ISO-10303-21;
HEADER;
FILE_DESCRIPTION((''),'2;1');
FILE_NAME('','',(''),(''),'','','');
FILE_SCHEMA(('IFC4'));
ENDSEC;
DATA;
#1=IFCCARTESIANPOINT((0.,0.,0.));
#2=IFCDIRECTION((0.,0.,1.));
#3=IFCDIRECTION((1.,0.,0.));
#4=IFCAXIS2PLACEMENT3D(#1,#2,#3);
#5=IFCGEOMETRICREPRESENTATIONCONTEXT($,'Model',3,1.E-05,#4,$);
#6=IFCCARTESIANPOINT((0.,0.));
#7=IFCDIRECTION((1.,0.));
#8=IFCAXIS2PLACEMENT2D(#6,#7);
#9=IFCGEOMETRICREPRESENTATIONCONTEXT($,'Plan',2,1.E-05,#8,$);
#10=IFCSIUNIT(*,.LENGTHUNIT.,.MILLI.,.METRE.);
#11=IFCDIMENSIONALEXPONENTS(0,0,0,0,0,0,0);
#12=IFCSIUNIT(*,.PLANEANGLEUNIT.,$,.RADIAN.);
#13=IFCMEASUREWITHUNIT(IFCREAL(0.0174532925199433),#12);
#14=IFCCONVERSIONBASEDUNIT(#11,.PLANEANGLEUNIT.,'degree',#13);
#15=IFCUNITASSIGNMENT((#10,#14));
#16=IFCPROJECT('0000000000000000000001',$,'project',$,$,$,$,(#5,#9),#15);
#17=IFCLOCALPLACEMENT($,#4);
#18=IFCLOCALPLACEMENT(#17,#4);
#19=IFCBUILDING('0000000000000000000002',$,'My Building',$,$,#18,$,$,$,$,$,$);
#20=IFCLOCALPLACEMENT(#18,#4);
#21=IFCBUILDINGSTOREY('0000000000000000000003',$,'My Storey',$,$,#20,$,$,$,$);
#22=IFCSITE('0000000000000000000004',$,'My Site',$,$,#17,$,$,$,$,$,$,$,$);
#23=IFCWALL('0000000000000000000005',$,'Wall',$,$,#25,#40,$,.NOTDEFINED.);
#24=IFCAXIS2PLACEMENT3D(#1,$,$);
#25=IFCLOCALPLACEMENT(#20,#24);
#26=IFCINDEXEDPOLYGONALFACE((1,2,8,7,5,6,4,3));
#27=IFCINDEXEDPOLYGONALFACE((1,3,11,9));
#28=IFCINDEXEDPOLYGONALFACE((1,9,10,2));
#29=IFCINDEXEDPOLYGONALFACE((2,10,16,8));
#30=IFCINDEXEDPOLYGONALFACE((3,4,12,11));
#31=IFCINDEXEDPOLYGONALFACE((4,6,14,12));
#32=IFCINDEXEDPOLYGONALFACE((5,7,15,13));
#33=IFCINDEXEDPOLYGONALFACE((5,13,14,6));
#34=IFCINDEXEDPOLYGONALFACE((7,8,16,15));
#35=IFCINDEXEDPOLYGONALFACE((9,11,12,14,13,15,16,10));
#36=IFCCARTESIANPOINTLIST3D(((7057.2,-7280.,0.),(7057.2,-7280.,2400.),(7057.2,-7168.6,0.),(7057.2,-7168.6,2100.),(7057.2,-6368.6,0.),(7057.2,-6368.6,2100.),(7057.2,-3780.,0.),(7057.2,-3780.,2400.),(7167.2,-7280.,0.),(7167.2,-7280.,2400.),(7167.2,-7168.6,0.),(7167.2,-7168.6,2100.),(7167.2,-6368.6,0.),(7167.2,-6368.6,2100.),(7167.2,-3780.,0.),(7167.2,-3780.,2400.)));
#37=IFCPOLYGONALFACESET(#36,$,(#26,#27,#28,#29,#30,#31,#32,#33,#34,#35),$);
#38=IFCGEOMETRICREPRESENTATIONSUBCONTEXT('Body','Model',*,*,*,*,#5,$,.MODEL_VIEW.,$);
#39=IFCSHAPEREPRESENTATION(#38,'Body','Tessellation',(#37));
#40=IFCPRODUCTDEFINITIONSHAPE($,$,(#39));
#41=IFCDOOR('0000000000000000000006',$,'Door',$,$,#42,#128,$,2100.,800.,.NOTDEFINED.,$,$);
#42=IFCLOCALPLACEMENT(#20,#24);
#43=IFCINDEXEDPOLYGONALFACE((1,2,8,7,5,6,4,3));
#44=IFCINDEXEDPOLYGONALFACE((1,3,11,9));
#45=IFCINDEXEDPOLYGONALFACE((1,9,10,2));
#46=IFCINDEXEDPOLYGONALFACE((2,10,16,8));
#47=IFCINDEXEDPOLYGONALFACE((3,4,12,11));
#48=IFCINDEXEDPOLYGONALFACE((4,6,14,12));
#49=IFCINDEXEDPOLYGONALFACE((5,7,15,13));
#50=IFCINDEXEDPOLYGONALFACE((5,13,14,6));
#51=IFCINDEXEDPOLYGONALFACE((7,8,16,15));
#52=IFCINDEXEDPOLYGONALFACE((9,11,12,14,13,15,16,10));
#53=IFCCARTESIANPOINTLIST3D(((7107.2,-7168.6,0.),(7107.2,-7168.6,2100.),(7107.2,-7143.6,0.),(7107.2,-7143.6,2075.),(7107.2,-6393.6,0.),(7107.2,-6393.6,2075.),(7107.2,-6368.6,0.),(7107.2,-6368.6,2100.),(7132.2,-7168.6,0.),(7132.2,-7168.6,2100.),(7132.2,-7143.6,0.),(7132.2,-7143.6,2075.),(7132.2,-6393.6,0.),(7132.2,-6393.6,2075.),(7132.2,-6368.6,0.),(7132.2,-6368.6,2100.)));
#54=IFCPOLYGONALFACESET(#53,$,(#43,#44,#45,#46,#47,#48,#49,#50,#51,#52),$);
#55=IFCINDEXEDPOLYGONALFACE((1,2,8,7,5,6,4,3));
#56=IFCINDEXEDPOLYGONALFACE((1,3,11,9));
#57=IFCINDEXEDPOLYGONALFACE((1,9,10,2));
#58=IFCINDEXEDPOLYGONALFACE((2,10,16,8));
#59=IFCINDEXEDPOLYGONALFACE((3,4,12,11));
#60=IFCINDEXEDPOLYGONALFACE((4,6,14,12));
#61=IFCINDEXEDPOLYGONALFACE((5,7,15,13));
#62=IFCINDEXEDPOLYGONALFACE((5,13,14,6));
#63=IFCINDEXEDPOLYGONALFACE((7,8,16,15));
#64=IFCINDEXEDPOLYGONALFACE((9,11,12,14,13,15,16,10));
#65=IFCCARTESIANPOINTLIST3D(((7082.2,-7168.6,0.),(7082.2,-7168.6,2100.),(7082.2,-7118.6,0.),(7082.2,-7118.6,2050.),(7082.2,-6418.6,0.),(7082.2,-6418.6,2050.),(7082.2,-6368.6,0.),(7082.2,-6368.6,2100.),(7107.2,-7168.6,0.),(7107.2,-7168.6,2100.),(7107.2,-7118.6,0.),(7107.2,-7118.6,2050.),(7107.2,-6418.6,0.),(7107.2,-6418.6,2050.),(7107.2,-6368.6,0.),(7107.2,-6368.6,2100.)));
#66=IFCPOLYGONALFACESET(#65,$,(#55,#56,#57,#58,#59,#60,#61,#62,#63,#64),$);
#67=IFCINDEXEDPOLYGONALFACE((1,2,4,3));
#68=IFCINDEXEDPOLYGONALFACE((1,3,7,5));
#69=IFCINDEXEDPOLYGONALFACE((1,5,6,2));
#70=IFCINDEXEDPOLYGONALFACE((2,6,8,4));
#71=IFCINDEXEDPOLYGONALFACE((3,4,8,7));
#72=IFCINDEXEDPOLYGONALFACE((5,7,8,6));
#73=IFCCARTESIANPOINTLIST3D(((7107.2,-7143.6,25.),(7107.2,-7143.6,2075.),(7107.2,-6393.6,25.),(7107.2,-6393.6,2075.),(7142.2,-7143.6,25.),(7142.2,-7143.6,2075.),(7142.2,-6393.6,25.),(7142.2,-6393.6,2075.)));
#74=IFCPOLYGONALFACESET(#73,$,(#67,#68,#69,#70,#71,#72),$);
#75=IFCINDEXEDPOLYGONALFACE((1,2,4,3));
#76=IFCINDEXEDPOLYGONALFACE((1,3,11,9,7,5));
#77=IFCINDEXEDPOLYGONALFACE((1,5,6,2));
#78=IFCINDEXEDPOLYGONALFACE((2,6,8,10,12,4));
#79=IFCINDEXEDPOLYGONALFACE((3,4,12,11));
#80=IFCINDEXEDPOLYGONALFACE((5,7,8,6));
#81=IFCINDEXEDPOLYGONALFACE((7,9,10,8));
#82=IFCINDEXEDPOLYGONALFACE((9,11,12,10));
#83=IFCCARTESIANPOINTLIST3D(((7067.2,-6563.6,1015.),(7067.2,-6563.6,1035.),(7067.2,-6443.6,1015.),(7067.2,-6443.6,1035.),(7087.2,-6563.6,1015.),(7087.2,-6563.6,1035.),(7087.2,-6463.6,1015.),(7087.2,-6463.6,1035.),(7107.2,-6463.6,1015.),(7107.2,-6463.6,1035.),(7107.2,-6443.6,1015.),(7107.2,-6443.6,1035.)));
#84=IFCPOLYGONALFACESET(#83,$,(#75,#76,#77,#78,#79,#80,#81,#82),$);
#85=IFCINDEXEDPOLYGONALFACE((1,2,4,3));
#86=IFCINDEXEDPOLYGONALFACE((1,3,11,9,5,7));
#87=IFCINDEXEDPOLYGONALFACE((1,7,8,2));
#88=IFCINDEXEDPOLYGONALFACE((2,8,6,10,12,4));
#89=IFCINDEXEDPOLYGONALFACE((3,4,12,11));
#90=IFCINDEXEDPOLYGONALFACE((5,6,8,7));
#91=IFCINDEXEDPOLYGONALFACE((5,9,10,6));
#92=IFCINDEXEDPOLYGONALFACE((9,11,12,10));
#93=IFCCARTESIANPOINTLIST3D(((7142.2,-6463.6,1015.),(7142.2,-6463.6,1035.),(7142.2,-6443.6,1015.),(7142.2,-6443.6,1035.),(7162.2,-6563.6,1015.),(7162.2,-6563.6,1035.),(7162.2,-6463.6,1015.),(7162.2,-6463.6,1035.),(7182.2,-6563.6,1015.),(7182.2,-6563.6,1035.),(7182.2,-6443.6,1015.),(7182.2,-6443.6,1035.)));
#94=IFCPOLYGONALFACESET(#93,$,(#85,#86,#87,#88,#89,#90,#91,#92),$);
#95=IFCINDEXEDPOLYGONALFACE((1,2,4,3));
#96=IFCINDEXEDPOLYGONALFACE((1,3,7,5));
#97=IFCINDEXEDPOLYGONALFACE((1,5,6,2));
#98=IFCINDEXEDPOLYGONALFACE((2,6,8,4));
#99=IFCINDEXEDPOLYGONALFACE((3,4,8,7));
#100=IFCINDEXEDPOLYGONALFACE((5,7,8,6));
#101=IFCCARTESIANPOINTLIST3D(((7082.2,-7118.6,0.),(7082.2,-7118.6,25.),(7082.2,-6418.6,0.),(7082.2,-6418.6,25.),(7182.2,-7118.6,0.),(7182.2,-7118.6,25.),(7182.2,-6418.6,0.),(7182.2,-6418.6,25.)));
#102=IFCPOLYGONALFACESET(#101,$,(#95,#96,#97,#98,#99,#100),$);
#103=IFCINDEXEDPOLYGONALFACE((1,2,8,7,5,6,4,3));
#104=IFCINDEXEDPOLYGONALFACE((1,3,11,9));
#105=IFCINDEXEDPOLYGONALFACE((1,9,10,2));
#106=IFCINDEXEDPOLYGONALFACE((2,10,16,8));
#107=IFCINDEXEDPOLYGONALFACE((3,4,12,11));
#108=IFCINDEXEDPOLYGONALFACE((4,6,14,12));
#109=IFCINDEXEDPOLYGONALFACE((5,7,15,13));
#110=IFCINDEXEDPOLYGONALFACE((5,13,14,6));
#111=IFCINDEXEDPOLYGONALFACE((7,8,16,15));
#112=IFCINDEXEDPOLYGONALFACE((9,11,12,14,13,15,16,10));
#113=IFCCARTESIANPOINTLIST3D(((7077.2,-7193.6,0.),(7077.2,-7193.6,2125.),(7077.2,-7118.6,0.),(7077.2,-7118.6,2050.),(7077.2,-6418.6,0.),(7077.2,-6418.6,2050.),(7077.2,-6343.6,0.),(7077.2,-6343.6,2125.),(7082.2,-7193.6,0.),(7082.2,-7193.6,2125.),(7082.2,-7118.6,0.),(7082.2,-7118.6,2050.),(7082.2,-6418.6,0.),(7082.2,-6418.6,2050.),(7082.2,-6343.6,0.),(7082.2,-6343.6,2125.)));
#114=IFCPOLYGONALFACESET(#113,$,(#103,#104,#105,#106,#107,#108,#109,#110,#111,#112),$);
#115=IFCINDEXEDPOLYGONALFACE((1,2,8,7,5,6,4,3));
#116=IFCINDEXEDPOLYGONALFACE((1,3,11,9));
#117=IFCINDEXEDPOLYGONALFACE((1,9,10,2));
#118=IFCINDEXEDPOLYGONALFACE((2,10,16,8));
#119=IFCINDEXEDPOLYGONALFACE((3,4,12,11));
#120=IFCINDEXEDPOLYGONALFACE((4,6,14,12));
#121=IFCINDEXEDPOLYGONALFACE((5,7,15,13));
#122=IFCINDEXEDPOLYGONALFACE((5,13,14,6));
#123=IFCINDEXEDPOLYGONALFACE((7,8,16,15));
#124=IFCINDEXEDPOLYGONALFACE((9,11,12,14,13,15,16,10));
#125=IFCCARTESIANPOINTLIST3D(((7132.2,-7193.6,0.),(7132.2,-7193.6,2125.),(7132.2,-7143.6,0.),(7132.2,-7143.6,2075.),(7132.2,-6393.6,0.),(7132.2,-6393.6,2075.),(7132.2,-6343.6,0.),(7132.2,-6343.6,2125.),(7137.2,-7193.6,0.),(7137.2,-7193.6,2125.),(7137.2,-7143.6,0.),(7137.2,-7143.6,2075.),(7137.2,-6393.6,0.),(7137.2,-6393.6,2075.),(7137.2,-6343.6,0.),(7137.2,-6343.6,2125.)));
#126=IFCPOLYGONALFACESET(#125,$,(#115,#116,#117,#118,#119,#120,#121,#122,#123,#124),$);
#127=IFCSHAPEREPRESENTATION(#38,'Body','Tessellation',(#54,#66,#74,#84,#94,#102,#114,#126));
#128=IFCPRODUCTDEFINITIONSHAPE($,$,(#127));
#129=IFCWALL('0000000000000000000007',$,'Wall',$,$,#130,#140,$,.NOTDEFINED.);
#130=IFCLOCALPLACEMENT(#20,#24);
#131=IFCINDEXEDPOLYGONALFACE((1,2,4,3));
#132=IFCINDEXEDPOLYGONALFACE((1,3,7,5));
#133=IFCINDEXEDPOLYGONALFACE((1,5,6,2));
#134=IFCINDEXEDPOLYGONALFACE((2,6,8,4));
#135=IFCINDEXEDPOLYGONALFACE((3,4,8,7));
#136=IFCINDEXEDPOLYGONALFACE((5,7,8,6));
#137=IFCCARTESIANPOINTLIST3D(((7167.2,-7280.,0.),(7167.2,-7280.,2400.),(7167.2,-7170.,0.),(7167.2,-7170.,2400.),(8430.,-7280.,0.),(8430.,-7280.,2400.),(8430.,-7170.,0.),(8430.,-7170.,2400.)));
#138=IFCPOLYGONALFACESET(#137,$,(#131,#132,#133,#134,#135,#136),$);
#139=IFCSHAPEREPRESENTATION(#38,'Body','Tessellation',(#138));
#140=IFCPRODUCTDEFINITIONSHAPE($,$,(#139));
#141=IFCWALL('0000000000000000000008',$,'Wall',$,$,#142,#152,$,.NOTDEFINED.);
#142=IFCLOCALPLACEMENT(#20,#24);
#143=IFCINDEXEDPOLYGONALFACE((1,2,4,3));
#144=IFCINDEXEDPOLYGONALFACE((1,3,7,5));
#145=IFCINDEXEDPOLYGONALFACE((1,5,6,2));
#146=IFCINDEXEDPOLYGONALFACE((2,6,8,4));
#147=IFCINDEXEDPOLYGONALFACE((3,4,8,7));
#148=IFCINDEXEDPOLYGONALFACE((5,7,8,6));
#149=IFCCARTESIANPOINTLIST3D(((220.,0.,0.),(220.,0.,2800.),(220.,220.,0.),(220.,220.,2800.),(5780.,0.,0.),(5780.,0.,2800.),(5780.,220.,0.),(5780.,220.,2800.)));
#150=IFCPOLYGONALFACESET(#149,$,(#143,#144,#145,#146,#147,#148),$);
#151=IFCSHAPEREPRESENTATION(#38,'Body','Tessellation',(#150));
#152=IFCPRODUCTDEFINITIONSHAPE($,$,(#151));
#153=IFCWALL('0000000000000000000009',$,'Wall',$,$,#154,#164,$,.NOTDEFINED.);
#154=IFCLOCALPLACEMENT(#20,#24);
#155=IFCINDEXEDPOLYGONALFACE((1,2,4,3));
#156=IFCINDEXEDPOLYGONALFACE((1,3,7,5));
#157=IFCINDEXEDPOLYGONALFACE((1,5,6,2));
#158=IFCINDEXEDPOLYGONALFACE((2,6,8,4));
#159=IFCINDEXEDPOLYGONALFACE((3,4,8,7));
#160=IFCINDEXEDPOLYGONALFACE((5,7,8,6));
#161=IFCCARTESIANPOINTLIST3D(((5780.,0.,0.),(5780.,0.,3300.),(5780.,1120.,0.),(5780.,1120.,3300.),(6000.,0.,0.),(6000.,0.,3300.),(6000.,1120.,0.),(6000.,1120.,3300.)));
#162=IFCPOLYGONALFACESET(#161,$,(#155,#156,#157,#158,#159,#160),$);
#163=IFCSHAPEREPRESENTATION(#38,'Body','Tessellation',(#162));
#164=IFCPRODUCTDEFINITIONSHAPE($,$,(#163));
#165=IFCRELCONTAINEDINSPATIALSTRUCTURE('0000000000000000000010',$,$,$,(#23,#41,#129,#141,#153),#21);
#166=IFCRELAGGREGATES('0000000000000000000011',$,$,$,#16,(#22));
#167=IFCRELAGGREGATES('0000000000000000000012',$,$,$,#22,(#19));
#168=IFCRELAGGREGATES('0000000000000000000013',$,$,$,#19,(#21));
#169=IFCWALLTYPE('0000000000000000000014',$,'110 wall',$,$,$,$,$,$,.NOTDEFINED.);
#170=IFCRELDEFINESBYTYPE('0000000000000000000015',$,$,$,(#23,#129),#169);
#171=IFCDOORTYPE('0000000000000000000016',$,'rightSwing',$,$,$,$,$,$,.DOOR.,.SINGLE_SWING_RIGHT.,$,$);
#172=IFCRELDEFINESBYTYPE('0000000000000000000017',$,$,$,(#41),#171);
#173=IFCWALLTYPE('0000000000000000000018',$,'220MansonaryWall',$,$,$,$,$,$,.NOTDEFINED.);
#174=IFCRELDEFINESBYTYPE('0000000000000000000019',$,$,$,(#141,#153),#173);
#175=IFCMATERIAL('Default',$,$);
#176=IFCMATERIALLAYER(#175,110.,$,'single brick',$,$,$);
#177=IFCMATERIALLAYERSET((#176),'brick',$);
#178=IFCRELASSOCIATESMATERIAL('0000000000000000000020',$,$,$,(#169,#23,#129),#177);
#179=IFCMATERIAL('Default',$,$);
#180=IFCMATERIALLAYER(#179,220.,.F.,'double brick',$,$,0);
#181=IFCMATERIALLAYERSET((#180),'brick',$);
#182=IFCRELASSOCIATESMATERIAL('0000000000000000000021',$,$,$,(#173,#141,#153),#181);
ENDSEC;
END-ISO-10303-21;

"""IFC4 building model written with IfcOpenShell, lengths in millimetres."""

from ifc_helpers import new_model, entity, si_unit, converted_unit, frame, origin_with_axes, origin_2d_with_axis, place, context, subcontext, project, spatial, line, indexed_curve, outline, extrude, shape, source, transform, mapped, material, layer, layer_set, layer_usage, type_object, type_shapes, element, fill, save


model = new_model("IFC4")

# Units and contexts
model_context = context("Model", 3, precision=1e-05, world=origin_with_axes())
plan_context = context("Plan", 2, precision=1e-05, world=origin_2d_with_axis())
body_context_1 = subcontext(model_context, "Body", "Model", "MODEL_VIEW")
body_context_2 = subcontext(plan_context, "Body", "Plan", "PLAN_VIEW")
ifc_project = project(units=[si_unit("LENGTHUNIT", "METRE", prefix="MILLI"), converted_unit("PLANEANGLEUNIT", "degree", entity("IfcReal", 0.0174532925199433), si_unit("PLANEANGLEUNIT", "RADIAN"), dimensions=[0, 0, 0, 0, 0, 0, 0])], contexts=[model_context, plan_context])

# Site, building, storey
site_placement = place(None, origin_with_axes())
site = spatial("IfcSite", under=ifc_project, at=site_placement, Name="My Site")
building_placement = place(site_placement, origin_with_axes())
building = spatial("IfcBuilding", under=site, at=building_placement, Name="My Building")
storey_placement = place(building_placement, origin_with_axes())
storey = spatial("IfcBuildingStorey", under=building, at=storey_placement, Name="My Storey")

# Shared definitions
ifc_material_1 = material(Name="Default")
ifc_layer_1 = layer(ifc_material_1, 110.0, Name="single brick")
ifc_layer_set_1 = layer_set([ifc_layer_1], Name="brick")
wall_type_1 = type_object("IfcWallType", Name="110 wall", PredefinedType="NOTDEFINED", material=ifc_layer_set_1)

# Shared definitions
shared_shape_1 = source(origin_with_axes(), body_context_1, "Body", "SweptSolid", [
    extrude(outline(indexed_curve([(0.0, 0.0, 0.0), (800.0, 0.0, 0.0), (800.0, 0.0, 2100.0), (0.0, 0.0, 2100.0)], segments=[line(1, 2), line(2, 3), line(3, 4), line(4, 1)])), frame((0.0, -100.0, 0.0), z_axis=(0.0, 0.0, 1.0), x_axis=(1.0, 0.0, 0.0)), (0.0, 1.0, 0.0), 310.0),
])
door_type_1 = type_object("IfcDoorType", Name="rightSwing", OperationType="SINGLE_SWING_RIGHT", PredefinedType="DOOR")
shared_shape_2 = source(origin_with_axes(), body_context_1, "Body", "SweptSolid", [
    extrude(outline(indexed_curve([(0.0, 0.0, 0.0), (0.0, 0.0, 2100.0), (800.0, 0.0, 2100.0), (800.0, 0.0, 0.0), (775.0, 0.0, 0.0), (775.0, 0.0, 2075.0), (25.0, 0.0, 2075.0), (25.0, 0.0, 0.0)], segments=[line(1, 2), line(2, 3), line(3, 4), line(4, 5), line(5, 6), line(6, 7), line(7, 8), line(8, 1)])), frame((0.0, 25.0, 0.0), z_axis=(0.0, 0.0, 1.0), x_axis=(1.0, 0.0, 0.0)), (0.0, 1.0, 0.0), 25.0),
    extrude(outline(indexed_curve([(0.0, 0.0, 0.0), (0.0, 0.0, 2100.0), (800.0, 0.0, 2100.0), (800.0, 0.0, 0.0), (750.0, 0.0, 0.0), (750.0, 0.0, 2050.0), (50.0, 0.0, 2050.0), (50.0, 0.0, 0.0)], segments=[line(1, 2), line(2, 3), line(3, 4), line(4, 5), line(5, 6), line(6, 7), line(7, 8), line(8, 1)])), origin_with_axes(), (0.0, 1.0, 0.0), 25.0),
    extrude(outline(indexed_curve([(0.0, 0.0), (750.0, 0.0), (750.0, 35.0), (0.0, 35.0)], segments=[line(1, 2), line(2, 3), line(3, 4), line(4, 1)])), frame((25.0, 25.0, 25.0), z_axis=(0.0, 0.0, 1.0), x_axis=(1.0, 0.0, 0.0)), (0.0, 0.0, 1.0), 2050.0),
    extrude(outline(indexed_curve([(0.0, 0.0), (0.0, -40.0), (120.0, -40.0), (120.0, -20.0), (20.0, -20.0), (20.0, 0.0)], segments=[line(1, 2), line(2, 3), line(3, 4), line(4, 5), line(5, 6), line(6, 1)])), frame((75.0, 25.0, 1015.0), z_axis=(0.0, 0.0, 1.0), x_axis=(1.0, 0.0, 0.0)), (0.0, 0.0, 1.0), 20.0),
    extrude(outline(indexed_curve([(0.0, 0.0), (0.0, 40.0), (120.0, 40.0), (120.0, 20.0), (20.0, 20.0), (20.0, 0.0)], segments=[line(1, 2), line(2, 3), line(3, 4), line(4, 5), line(5, 6), line(6, 1)])), frame((75.0, 60.0, 1015.0), z_axis=(0.0, 0.0, 1.0), x_axis=(1.0, 0.0, 0.0)), (0.0, 0.0, 1.0), 20.0),
    extrude(outline(indexed_curve([(0.0, 0.0), (700.0, 0.0), (700.0, 100.0), (0.0, 100.0)], segments=[line(1, 2), line(2, 3), line(3, 4), line(4, 1)])), frame((50.0, 0.0, 0.0), z_axis=(0.0, 0.0, 1.0), x_axis=(1.0, 0.0, 0.0)), (0.0, 0.0, 1.0), 25.0),
    extrude(outline(indexed_curve([(0.0, 0.0, 0.0), (0.0, 0.0, 2125.0), (850.0, 0.0, 2125.0), (850.0, 0.0, 0.0), (775.0, 0.0, 0.0), (775.0, 0.0, 2050.0), (75.0, 0.0, 2050.0), (75.0, 0.0, 0.0)], segments=[line(1, 2), line(2, 3), line(3, 4), line(4, 5), line(5, 6), line(6, 7), line(7, 8), line(8, 1)])), frame((-25.0, -5.0, 0.0), z_axis=(0.0, 0.0, 1.0), x_axis=(1.0, 0.0, 0.0)), (0.0, 1.0, 0.0), 5.0),
    extrude(outline(indexed_curve([(0.0, 0.0, 0.0), (0.0, 0.0, 2125.0), (850.0, 0.0, 2125.0), (850.0, 0.0, 0.0), (800.0, 0.0, 0.0), (800.0, 0.0, 2075.0), (50.0, 0.0, 2075.0), (50.0, 0.0, 0.0)], segments=[line(1, 2), line(2, 3), line(3, 4), line(4, 5), line(5, 6), line(6, 7), line(7, 8), line(8, 1)])), frame((-25.0, 50.0, 0.0), z_axis=(0.0, 0.0, 1.0), x_axis=(1.0, 0.0, 0.0)), (0.0, 1.0, 0.0), 5.0),
])
shared_shape_3 = source(origin_with_axes(), body_context_2, "Body", "Curve2D", [
    entity("IfcIndexedPolyCurve", entity("IfcCartesianPointList2D", [[0.0, 0.0], [0.0, 50.0], [25.0, 50.0], [25.0, 25.0], [50.0, 25.0], [50.0, 0.0]]), [entity("IfcLineIndex", [1, 2]), entity("IfcLineIndex", [2, 3]), entity("IfcLineIndex", [3, 4]), entity("IfcLineIndex", [4, 5]), entity("IfcLineIndex", [5, 6]), entity("IfcLineIndex", [6, 1])]),
    entity("IfcIndexedPolyCurve", entity("IfcCartesianPointList2D", [[800.0, 0.0], [800.0, 50.0], [775.0, 50.0], [775.0, 25.0], [750.0, 25.0], [750.0, 0.0]]), [entity("IfcLineIndex", [1, 2]), entity("IfcLineIndex", [2, 3]), entity("IfcLineIndex", [3, 4]), entity("IfcLineIndex", [4, 5]), entity("IfcLineIndex", [5, 6]), entity("IfcLineIndex", [6, 1])]),
    entity("IfcTrimmedCurve", entity("IfcEllipse", entity("IfcAxis2Placement2D", entity("IfcCartesianPoint", [740.0, 50.0]), entity("IfcDirection", [1.0, 0.0])), 715.0, 750.0), [entity("IfcCartesianPoint", [740.0, 800.0])], [entity("IfcCartesianPoint", [25.0, 50.0])], True, "CARTESIAN"),
    entity("IfcIndexedPolyCurve", entity("IfcCartesianPointList2D", [[775.0, 50.0], [740.0, 50.0], [740.0, 800.0], [775.0, 800.0]]), [entity("IfcLineIndex", [1, 2]), entity("IfcLineIndex", [2, 3]), entity("IfcLineIndex", [3, 4]), entity("IfcLineIndex", [4, 1])]),
])
type_shapes(door_type_1, [shared_shape_2, shared_shape_3])

# Wall, opening, door
ifc_layer_usage_1 = layer_usage(ifc_layer_set_1, "AXIS2", "POSITIVE", 0.0)
wall_1_placement = place(storey_placement, frame((7167.2, -7280.0, 0.0), z_axis=(0.0, 0.0, 1.0), x_axis=(0.000001, 1.0, 0.0)))
wall_1 = element("IfcWall", 1, at=wall_1_placement, inside=storey, type_object=wall_type_1, material=ifc_layer_usage_1, Name="Wall", PredefinedType="NOTDEFINED", context=body_context_1, shape_type="SweptSolid", body=[
    extrude(outline(indexed_curve([(0.0, 0.0), (0.0, 110.0), (3500.0, 110.0), (3500.0, 0.0), (0.0, 0.0)], self_intersect=False)), origin_with_axes(), (0.0, 0.0, 1.0), 2400.0),
])
opening_1_placement = place(wall_1_placement, frame((911.4, 85.0, 0.0), z_axis=(0.0, 0.0, 1.0), x_axis=(-1.0, 0.0, 0.0)))
opening_1 = element("IfcOpeningElement", 2, at=opening_1_placement, cuts=wall_1, PredefinedType="OPENING", context=body_context_1, shape_type="MappedRepresentation", body=[
    mapped(shared_shape_1, transform((0.0, 0.0, 0.0), x_axis=(1.0, 0.0, 0.0), y_axis=(0.0, 1.0, 0.0), z_axis=(0.0, 0.0, 1.0), scale=1.0)),
])
door_1_placement = place(storey_placement, frame((7082.2, -6368.6, 0.0), z_axis=(0.0, 0.0, 1.0), x_axis=(-0.000001, -1.0, 0.0)))
door_1 = element("IfcDoor", 3, at=door_1_placement, inside=storey, type_object=door_type_1, Name="Door", OverallHeight=2100.0, OverallWidth=800.0, PredefinedType="NOTDEFINED", shapes=[
    shape(body_context_1, "Body", "MappedRepresentation", [mapped(shared_shape_2, transform((0.0, 0.0, 0.0), x_axis=(1.0, 0.0, 0.0), y_axis=(0.0, 1.0, 0.0), z_axis=(0.0, 0.0, 1.0), scale=1.0))]),
    shape(body_context_2, "Body", "MappedRepresentation", [mapped(shared_shape_3, transform((0.0, 0.0, 0.0), x_axis=(1.0, 0.0, 0.0), y_axis=(0.0, 1.0, 0.0), z_axis=(0.0, 0.0, 1.0), scale=1.0))]),
])
fill(opening_1, door_1)

# Walls
ifc_layer_usage_2 = layer_usage(ifc_layer_set_1, "AXIS2", "POSITIVE", 0.0)
wall_2_placement = place(storey_placement, frame((7167.2, -7280.0, 0.0), z_axis=(0.0, 0.0, 1.0), x_axis=(1.0, -0.000001, 0.0)))
element("IfcWall", 4, at=wall_2_placement, inside=storey, type_object=wall_type_1, material=ifc_layer_usage_2, Name="Wall", PredefinedType="NOTDEFINED", context=body_context_1, shape_type="SweptSolid", body=[
    extrude(outline(indexed_curve([(0.0, 0.0), (0.0, 110.0), (1262.8, 110.0), (1262.8, 0.0), (0.0, 0.0)], self_intersect=False)), origin_with_axes(), (0.0, 0.0, 1.0), 2400.0),
])
ifc_material_2 = material(Name="Default")
ifc_layer_2 = layer(ifc_material_2, 220.0, ventilated=False, Name="double brick", Priority=0)
ifc_layer_set_2 = layer_set([ifc_layer_2], Name="brick")
ifc_layer_usage_3 = layer_usage(ifc_layer_set_2, "AXIS2", "POSITIVE", 0.0)
wall_type_2 = type_object("IfcWallType", Name="220MansonaryWall", PredefinedType="NOTDEFINED", material=ifc_layer_set_2)
wall_3_placement = place(storey_placement, frame((220.0, 0.0, 0.0), z_axis=(0.0, 0.0, 1.0), x_axis=(1.0, 0.0, 0.0)))
element("IfcWall", 5, at=wall_3_placement, inside=storey, type_object=wall_type_2, material=ifc_layer_usage_3, Name="Wall", PredefinedType="NOTDEFINED", context=body_context_1, shape_type="SweptSolid", body=[
    extrude(outline(indexed_curve([(0.0, 0.0), (0.0, 220.0), (5560.0, 220.0), (5560.0, 0.0), (0.0, 0.0)], self_intersect=False)), origin_with_axes(), (0.0, 0.0, 1.0), 2800.0),
])
ifc_layer_usage_4 = layer_usage(ifc_layer_set_2, "AXIS2", "POSITIVE", 0.0)
wall_4_placement = place(storey_placement, frame((6000.0, 0.0, 0.0), z_axis=(0.0, 0.0, 1.0), x_axis=(0.0, 1.0, 0.0)))
element("IfcWall", 6, at=wall_4_placement, inside=storey, type_object=wall_type_2, material=ifc_layer_usage_4, Name="Wall", PredefinedType="NOTDEFINED", context=body_context_1, shape_type="SweptSolid", body=[
    extrude(outline(indexed_curve([(0.0, 0.0), (0.0, 220.0), (1120.0, 220.0), (1120.0, 0.0), (0.0, 0.0)], self_intersect=False)), origin_with_axes(), (0.0, 0.0, 1.0), 3300.0),
])

save(model, "model.ifc")
